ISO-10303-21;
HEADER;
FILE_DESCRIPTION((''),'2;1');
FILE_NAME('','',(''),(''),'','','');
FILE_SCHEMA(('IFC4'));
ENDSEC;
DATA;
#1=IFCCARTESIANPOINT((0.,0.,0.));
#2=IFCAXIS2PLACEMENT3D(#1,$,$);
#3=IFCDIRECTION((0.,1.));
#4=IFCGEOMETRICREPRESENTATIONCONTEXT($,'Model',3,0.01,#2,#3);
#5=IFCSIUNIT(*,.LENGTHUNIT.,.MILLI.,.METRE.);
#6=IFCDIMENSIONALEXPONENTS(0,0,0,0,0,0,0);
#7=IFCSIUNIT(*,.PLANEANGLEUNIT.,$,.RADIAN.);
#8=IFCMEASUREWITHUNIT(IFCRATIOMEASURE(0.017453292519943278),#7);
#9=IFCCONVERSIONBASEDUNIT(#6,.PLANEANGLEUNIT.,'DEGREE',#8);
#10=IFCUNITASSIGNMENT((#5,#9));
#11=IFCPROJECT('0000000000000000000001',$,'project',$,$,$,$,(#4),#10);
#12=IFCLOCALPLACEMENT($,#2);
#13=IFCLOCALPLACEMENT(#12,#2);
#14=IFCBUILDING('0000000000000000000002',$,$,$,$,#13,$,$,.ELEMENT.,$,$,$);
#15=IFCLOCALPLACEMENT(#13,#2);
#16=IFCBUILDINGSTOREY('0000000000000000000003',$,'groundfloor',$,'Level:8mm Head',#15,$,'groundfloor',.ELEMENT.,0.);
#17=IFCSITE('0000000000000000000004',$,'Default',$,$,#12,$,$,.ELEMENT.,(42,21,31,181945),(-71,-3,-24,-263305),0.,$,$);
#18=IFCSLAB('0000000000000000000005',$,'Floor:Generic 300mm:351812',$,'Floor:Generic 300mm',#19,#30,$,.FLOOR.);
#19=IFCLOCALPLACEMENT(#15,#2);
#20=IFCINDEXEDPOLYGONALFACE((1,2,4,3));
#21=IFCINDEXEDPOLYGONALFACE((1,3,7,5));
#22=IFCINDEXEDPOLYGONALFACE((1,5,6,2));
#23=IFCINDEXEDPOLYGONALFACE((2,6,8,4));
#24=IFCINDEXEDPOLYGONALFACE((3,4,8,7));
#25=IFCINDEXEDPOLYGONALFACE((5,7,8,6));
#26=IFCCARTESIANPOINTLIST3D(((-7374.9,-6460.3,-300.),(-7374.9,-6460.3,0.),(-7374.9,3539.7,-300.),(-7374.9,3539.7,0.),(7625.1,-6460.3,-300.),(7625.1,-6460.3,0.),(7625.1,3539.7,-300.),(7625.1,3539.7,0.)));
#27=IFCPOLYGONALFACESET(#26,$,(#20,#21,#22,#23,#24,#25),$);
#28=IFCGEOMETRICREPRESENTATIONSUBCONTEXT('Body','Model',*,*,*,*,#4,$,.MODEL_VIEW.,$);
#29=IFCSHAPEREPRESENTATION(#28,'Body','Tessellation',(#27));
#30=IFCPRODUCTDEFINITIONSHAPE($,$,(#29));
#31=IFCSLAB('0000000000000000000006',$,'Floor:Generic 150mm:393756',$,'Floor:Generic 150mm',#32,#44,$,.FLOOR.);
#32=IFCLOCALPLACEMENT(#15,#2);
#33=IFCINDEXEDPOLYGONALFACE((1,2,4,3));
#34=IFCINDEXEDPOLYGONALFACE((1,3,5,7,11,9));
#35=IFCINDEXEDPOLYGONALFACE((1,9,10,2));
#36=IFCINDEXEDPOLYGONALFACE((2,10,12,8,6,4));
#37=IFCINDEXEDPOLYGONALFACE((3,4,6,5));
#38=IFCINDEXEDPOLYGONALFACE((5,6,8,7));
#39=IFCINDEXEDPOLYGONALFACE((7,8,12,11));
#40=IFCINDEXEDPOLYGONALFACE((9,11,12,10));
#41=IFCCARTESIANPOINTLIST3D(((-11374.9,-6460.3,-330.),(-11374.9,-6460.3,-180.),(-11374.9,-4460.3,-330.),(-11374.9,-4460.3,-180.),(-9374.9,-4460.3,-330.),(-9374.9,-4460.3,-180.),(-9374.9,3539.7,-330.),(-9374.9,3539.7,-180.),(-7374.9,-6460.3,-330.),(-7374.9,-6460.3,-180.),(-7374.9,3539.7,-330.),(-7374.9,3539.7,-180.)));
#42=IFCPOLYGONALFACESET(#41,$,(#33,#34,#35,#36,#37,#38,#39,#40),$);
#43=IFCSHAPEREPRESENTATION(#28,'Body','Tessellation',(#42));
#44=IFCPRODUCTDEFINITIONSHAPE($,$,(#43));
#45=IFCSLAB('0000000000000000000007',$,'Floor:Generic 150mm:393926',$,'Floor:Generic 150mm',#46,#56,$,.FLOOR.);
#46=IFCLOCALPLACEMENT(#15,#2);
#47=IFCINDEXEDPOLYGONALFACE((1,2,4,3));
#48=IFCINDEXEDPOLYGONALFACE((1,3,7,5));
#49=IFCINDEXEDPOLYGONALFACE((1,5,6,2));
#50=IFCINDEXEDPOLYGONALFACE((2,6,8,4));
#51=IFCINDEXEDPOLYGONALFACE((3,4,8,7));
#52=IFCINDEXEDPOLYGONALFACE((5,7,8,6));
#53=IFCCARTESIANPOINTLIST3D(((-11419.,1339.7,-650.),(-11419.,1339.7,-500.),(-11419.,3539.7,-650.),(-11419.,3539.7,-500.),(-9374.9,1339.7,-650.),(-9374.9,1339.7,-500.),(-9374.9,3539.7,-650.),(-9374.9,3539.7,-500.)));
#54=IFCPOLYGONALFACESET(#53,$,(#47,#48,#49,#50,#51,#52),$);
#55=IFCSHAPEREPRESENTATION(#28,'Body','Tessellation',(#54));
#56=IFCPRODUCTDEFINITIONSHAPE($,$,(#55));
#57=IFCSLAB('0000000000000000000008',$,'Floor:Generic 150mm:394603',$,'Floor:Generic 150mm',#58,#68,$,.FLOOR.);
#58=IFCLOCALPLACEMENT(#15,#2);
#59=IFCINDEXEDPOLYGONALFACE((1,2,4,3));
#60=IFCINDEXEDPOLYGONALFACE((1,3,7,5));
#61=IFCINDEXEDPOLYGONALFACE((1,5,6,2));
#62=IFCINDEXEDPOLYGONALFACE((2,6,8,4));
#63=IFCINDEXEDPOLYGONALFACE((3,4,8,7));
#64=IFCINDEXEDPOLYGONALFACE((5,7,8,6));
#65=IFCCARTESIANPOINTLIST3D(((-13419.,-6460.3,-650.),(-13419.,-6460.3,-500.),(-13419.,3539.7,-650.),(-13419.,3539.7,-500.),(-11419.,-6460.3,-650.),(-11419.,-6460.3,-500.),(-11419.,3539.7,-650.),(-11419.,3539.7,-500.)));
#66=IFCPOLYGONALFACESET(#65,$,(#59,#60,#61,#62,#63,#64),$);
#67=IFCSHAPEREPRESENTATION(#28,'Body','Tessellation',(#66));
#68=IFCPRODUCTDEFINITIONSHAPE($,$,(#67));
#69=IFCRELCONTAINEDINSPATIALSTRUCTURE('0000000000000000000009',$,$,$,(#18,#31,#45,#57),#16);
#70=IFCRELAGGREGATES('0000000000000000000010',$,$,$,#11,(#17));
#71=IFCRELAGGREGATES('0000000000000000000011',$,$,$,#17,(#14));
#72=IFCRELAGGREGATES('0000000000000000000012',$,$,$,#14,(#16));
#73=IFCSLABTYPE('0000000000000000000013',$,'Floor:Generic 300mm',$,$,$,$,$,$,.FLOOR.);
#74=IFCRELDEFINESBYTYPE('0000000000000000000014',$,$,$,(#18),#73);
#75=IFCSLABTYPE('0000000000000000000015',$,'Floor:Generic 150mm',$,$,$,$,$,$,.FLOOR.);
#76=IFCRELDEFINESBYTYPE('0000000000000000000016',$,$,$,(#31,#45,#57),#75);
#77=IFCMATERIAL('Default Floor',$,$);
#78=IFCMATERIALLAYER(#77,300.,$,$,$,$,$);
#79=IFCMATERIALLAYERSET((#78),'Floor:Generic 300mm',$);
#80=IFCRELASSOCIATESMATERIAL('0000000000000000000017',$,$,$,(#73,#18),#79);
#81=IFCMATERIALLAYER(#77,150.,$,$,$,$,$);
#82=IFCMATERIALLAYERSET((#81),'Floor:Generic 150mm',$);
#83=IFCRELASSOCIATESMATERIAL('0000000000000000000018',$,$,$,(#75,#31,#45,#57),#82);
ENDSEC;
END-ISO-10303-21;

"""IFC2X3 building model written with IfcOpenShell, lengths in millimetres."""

from ifc_helpers import new_model, entity, si_unit, converted_unit, direction, frame, frame_2d, origin, origin_2d_with_axis, place, context, subcontext, project, spatial, polyline, rectangle, outline, extrude, material, layer, layer_set, layer_usage, type_object, element, save


model = new_model("IFC2X3")

# Units and contexts
model_context = context("Model", 3, precision=0.01, world=origin(), true_north=direction((0.0, 1.0)))
body_context = subcontext(model_context, "Body", "Model", "MODEL_VIEW")
ifc_project = project(units=[si_unit("LENGTHUNIT", "METRE", prefix="MILLI"), converted_unit("PLANEANGLEUNIT", "DEGREE", entity("IfcRatioMeasure", 0.017453292519943278), si_unit("PLANEANGLEUNIT", "RADIAN"), dimensions=[0, 0, 0, 0, 0, 0, 0])], contexts=[model_context])

# Site, building, storey
site_placement = place(None, origin())
site = spatial("IfcSite", under=ifc_project, at=site_placement, Name="Default", CompositionType="ELEMENT", RefLatitude=(42, 21, 31, 181945), RefLongitude=(-71, -3, -24, -263305), RefElevation=0.0)
building_placement = place(site_placement, origin())
building = spatial("IfcBuilding", under=site, at=building_placement, CompositionType="ELEMENT")
storey_placement = place(building_placement, origin())
storey = spatial("IfcBuildingStorey", under=building, at=storey_placement, Name="groundfloor", ObjectType="Level:8mm Head", LongName="groundfloor", CompositionType="ELEMENT", Elevation=0.0)

# Slabs
ifc_material_1 = material(Name="Default Floor")
ifc_layer_1 = layer(ifc_material_1, 300.0)
ifc_layer_set_1 = layer_set([ifc_layer_1], Name="Floor:Generic 300mm")
ifc_layer_usage_1 = layer_usage(ifc_layer_set_1, "AXIS3", "POSITIVE", 0.0)
slab_type_1 = type_object("IfcSlabType", Name="Floor:Generic 300mm", PredefinedType="FLOOR", material=ifc_layer_set_1)
slab_1_placement = place(storey_placement, origin())
element("IfcSlab", 1, at=slab_1_placement, inside=storey, type_object=slab_type_1, material=ifc_layer_usage_1, Name="Floor:Generic 300mm:351812", ObjectType="Floor:Generic 300mm", PredefinedType="FLOOR", context=body_context, shape_type="SweptSolid", body=[
    extrude(rectangle(XDim=10000.0, YDim=15000.0, at=origin_2d_with_axis()), frame((125.1, -1460.3, 0.0), z_axis=(0.0, 0.0, -1.0), x_axis=(0.0, 1.0, 0.0)), (0.0, 0.0, 1.0), 300.0),
])
ifc_layer_2 = layer(ifc_material_1, 150.0)
ifc_layer_set_2 = layer_set([ifc_layer_2], Name="Floor:Generic 150mm")
ifc_layer_usage_2 = layer_usage(ifc_layer_set_2, "AXIS3", "POSITIVE", 0.0)
slab_type_2 = type_object("IfcSlabType", Name="Floor:Generic 150mm", PredefinedType="FLOOR", material=ifc_layer_set_2)
slab_2_placement = place(storey_placement, origin())
element("IfcSlab", 2, at=slab_2_placement, inside=storey, type_object=slab_type_2, material=ifc_layer_usage_2, Name="Floor:Generic 150mm:393756", ObjectType="Floor:Generic 150mm", PredefinedType="FLOOR", context=body_context, shape_type="SweptSolid", body=[
    extrude(outline(polyline([(-4000.0, -2000.0), (-2000.0, -2000.0), (-2000.0, 0.0), (6000.0, 0.0), (6000.0, 2000.0), (-4000.0, 2000.0), (-4000.0, -2000.0)])), frame((-9374.9, -2460.3, -180.0), z_axis=(0.0, 0.0, -1.0), x_axis=(0.0, 1.0, 0.0)), (0.0, 0.0, 1.0), 150.0),
])
slab_3_placement = place(storey_placement, origin())
element("IfcSlab", 3, at=slab_3_placement, inside=storey, type_object=slab_type_2, material=ifc_layer_usage_2, Name="Floor:Generic 150mm:393926", ObjectType="Floor:Generic 150mm", PredefinedType="FLOOR", context=body_context, shape_type="SweptSolid", body=[
    extrude(rectangle(XDim=2200.0, YDim=2044.0, at=frame_2d((0.0, 0.0), x_axis=(1.0, 0.0))), frame((-10397.0, 2439.7, -500.0), z_axis=(0.0, 0.0, -1.0), x_axis=(0.0, 1.0, 0.0)), (0.0, 0.0, 1.0), 150.0),
])
slab_4_placement = place(storey_placement, origin())
element("IfcSlab", 4, at=slab_4_placement, inside=storey, type_object=slab_type_2, material=ifc_layer_usage_2, Name="Floor:Generic 150mm:394603", ObjectType="Floor:Generic 150mm", PredefinedType="FLOOR", context=body_context, shape_type="SweptSolid", body=[
    extrude(rectangle(XDim=10000.0, YDim=2000.0, at=frame_2d((0.0, 0.0), x_axis=(1.0, 0.0))), frame((-12419.0, -1460.3, -500.0), z_axis=(0.0, 0.0, -1.0), x_axis=(0.0, 1.0, 0.0)), (0.0, 0.0, 1.0), 150.0),
])

save(model, "model.ifc")
